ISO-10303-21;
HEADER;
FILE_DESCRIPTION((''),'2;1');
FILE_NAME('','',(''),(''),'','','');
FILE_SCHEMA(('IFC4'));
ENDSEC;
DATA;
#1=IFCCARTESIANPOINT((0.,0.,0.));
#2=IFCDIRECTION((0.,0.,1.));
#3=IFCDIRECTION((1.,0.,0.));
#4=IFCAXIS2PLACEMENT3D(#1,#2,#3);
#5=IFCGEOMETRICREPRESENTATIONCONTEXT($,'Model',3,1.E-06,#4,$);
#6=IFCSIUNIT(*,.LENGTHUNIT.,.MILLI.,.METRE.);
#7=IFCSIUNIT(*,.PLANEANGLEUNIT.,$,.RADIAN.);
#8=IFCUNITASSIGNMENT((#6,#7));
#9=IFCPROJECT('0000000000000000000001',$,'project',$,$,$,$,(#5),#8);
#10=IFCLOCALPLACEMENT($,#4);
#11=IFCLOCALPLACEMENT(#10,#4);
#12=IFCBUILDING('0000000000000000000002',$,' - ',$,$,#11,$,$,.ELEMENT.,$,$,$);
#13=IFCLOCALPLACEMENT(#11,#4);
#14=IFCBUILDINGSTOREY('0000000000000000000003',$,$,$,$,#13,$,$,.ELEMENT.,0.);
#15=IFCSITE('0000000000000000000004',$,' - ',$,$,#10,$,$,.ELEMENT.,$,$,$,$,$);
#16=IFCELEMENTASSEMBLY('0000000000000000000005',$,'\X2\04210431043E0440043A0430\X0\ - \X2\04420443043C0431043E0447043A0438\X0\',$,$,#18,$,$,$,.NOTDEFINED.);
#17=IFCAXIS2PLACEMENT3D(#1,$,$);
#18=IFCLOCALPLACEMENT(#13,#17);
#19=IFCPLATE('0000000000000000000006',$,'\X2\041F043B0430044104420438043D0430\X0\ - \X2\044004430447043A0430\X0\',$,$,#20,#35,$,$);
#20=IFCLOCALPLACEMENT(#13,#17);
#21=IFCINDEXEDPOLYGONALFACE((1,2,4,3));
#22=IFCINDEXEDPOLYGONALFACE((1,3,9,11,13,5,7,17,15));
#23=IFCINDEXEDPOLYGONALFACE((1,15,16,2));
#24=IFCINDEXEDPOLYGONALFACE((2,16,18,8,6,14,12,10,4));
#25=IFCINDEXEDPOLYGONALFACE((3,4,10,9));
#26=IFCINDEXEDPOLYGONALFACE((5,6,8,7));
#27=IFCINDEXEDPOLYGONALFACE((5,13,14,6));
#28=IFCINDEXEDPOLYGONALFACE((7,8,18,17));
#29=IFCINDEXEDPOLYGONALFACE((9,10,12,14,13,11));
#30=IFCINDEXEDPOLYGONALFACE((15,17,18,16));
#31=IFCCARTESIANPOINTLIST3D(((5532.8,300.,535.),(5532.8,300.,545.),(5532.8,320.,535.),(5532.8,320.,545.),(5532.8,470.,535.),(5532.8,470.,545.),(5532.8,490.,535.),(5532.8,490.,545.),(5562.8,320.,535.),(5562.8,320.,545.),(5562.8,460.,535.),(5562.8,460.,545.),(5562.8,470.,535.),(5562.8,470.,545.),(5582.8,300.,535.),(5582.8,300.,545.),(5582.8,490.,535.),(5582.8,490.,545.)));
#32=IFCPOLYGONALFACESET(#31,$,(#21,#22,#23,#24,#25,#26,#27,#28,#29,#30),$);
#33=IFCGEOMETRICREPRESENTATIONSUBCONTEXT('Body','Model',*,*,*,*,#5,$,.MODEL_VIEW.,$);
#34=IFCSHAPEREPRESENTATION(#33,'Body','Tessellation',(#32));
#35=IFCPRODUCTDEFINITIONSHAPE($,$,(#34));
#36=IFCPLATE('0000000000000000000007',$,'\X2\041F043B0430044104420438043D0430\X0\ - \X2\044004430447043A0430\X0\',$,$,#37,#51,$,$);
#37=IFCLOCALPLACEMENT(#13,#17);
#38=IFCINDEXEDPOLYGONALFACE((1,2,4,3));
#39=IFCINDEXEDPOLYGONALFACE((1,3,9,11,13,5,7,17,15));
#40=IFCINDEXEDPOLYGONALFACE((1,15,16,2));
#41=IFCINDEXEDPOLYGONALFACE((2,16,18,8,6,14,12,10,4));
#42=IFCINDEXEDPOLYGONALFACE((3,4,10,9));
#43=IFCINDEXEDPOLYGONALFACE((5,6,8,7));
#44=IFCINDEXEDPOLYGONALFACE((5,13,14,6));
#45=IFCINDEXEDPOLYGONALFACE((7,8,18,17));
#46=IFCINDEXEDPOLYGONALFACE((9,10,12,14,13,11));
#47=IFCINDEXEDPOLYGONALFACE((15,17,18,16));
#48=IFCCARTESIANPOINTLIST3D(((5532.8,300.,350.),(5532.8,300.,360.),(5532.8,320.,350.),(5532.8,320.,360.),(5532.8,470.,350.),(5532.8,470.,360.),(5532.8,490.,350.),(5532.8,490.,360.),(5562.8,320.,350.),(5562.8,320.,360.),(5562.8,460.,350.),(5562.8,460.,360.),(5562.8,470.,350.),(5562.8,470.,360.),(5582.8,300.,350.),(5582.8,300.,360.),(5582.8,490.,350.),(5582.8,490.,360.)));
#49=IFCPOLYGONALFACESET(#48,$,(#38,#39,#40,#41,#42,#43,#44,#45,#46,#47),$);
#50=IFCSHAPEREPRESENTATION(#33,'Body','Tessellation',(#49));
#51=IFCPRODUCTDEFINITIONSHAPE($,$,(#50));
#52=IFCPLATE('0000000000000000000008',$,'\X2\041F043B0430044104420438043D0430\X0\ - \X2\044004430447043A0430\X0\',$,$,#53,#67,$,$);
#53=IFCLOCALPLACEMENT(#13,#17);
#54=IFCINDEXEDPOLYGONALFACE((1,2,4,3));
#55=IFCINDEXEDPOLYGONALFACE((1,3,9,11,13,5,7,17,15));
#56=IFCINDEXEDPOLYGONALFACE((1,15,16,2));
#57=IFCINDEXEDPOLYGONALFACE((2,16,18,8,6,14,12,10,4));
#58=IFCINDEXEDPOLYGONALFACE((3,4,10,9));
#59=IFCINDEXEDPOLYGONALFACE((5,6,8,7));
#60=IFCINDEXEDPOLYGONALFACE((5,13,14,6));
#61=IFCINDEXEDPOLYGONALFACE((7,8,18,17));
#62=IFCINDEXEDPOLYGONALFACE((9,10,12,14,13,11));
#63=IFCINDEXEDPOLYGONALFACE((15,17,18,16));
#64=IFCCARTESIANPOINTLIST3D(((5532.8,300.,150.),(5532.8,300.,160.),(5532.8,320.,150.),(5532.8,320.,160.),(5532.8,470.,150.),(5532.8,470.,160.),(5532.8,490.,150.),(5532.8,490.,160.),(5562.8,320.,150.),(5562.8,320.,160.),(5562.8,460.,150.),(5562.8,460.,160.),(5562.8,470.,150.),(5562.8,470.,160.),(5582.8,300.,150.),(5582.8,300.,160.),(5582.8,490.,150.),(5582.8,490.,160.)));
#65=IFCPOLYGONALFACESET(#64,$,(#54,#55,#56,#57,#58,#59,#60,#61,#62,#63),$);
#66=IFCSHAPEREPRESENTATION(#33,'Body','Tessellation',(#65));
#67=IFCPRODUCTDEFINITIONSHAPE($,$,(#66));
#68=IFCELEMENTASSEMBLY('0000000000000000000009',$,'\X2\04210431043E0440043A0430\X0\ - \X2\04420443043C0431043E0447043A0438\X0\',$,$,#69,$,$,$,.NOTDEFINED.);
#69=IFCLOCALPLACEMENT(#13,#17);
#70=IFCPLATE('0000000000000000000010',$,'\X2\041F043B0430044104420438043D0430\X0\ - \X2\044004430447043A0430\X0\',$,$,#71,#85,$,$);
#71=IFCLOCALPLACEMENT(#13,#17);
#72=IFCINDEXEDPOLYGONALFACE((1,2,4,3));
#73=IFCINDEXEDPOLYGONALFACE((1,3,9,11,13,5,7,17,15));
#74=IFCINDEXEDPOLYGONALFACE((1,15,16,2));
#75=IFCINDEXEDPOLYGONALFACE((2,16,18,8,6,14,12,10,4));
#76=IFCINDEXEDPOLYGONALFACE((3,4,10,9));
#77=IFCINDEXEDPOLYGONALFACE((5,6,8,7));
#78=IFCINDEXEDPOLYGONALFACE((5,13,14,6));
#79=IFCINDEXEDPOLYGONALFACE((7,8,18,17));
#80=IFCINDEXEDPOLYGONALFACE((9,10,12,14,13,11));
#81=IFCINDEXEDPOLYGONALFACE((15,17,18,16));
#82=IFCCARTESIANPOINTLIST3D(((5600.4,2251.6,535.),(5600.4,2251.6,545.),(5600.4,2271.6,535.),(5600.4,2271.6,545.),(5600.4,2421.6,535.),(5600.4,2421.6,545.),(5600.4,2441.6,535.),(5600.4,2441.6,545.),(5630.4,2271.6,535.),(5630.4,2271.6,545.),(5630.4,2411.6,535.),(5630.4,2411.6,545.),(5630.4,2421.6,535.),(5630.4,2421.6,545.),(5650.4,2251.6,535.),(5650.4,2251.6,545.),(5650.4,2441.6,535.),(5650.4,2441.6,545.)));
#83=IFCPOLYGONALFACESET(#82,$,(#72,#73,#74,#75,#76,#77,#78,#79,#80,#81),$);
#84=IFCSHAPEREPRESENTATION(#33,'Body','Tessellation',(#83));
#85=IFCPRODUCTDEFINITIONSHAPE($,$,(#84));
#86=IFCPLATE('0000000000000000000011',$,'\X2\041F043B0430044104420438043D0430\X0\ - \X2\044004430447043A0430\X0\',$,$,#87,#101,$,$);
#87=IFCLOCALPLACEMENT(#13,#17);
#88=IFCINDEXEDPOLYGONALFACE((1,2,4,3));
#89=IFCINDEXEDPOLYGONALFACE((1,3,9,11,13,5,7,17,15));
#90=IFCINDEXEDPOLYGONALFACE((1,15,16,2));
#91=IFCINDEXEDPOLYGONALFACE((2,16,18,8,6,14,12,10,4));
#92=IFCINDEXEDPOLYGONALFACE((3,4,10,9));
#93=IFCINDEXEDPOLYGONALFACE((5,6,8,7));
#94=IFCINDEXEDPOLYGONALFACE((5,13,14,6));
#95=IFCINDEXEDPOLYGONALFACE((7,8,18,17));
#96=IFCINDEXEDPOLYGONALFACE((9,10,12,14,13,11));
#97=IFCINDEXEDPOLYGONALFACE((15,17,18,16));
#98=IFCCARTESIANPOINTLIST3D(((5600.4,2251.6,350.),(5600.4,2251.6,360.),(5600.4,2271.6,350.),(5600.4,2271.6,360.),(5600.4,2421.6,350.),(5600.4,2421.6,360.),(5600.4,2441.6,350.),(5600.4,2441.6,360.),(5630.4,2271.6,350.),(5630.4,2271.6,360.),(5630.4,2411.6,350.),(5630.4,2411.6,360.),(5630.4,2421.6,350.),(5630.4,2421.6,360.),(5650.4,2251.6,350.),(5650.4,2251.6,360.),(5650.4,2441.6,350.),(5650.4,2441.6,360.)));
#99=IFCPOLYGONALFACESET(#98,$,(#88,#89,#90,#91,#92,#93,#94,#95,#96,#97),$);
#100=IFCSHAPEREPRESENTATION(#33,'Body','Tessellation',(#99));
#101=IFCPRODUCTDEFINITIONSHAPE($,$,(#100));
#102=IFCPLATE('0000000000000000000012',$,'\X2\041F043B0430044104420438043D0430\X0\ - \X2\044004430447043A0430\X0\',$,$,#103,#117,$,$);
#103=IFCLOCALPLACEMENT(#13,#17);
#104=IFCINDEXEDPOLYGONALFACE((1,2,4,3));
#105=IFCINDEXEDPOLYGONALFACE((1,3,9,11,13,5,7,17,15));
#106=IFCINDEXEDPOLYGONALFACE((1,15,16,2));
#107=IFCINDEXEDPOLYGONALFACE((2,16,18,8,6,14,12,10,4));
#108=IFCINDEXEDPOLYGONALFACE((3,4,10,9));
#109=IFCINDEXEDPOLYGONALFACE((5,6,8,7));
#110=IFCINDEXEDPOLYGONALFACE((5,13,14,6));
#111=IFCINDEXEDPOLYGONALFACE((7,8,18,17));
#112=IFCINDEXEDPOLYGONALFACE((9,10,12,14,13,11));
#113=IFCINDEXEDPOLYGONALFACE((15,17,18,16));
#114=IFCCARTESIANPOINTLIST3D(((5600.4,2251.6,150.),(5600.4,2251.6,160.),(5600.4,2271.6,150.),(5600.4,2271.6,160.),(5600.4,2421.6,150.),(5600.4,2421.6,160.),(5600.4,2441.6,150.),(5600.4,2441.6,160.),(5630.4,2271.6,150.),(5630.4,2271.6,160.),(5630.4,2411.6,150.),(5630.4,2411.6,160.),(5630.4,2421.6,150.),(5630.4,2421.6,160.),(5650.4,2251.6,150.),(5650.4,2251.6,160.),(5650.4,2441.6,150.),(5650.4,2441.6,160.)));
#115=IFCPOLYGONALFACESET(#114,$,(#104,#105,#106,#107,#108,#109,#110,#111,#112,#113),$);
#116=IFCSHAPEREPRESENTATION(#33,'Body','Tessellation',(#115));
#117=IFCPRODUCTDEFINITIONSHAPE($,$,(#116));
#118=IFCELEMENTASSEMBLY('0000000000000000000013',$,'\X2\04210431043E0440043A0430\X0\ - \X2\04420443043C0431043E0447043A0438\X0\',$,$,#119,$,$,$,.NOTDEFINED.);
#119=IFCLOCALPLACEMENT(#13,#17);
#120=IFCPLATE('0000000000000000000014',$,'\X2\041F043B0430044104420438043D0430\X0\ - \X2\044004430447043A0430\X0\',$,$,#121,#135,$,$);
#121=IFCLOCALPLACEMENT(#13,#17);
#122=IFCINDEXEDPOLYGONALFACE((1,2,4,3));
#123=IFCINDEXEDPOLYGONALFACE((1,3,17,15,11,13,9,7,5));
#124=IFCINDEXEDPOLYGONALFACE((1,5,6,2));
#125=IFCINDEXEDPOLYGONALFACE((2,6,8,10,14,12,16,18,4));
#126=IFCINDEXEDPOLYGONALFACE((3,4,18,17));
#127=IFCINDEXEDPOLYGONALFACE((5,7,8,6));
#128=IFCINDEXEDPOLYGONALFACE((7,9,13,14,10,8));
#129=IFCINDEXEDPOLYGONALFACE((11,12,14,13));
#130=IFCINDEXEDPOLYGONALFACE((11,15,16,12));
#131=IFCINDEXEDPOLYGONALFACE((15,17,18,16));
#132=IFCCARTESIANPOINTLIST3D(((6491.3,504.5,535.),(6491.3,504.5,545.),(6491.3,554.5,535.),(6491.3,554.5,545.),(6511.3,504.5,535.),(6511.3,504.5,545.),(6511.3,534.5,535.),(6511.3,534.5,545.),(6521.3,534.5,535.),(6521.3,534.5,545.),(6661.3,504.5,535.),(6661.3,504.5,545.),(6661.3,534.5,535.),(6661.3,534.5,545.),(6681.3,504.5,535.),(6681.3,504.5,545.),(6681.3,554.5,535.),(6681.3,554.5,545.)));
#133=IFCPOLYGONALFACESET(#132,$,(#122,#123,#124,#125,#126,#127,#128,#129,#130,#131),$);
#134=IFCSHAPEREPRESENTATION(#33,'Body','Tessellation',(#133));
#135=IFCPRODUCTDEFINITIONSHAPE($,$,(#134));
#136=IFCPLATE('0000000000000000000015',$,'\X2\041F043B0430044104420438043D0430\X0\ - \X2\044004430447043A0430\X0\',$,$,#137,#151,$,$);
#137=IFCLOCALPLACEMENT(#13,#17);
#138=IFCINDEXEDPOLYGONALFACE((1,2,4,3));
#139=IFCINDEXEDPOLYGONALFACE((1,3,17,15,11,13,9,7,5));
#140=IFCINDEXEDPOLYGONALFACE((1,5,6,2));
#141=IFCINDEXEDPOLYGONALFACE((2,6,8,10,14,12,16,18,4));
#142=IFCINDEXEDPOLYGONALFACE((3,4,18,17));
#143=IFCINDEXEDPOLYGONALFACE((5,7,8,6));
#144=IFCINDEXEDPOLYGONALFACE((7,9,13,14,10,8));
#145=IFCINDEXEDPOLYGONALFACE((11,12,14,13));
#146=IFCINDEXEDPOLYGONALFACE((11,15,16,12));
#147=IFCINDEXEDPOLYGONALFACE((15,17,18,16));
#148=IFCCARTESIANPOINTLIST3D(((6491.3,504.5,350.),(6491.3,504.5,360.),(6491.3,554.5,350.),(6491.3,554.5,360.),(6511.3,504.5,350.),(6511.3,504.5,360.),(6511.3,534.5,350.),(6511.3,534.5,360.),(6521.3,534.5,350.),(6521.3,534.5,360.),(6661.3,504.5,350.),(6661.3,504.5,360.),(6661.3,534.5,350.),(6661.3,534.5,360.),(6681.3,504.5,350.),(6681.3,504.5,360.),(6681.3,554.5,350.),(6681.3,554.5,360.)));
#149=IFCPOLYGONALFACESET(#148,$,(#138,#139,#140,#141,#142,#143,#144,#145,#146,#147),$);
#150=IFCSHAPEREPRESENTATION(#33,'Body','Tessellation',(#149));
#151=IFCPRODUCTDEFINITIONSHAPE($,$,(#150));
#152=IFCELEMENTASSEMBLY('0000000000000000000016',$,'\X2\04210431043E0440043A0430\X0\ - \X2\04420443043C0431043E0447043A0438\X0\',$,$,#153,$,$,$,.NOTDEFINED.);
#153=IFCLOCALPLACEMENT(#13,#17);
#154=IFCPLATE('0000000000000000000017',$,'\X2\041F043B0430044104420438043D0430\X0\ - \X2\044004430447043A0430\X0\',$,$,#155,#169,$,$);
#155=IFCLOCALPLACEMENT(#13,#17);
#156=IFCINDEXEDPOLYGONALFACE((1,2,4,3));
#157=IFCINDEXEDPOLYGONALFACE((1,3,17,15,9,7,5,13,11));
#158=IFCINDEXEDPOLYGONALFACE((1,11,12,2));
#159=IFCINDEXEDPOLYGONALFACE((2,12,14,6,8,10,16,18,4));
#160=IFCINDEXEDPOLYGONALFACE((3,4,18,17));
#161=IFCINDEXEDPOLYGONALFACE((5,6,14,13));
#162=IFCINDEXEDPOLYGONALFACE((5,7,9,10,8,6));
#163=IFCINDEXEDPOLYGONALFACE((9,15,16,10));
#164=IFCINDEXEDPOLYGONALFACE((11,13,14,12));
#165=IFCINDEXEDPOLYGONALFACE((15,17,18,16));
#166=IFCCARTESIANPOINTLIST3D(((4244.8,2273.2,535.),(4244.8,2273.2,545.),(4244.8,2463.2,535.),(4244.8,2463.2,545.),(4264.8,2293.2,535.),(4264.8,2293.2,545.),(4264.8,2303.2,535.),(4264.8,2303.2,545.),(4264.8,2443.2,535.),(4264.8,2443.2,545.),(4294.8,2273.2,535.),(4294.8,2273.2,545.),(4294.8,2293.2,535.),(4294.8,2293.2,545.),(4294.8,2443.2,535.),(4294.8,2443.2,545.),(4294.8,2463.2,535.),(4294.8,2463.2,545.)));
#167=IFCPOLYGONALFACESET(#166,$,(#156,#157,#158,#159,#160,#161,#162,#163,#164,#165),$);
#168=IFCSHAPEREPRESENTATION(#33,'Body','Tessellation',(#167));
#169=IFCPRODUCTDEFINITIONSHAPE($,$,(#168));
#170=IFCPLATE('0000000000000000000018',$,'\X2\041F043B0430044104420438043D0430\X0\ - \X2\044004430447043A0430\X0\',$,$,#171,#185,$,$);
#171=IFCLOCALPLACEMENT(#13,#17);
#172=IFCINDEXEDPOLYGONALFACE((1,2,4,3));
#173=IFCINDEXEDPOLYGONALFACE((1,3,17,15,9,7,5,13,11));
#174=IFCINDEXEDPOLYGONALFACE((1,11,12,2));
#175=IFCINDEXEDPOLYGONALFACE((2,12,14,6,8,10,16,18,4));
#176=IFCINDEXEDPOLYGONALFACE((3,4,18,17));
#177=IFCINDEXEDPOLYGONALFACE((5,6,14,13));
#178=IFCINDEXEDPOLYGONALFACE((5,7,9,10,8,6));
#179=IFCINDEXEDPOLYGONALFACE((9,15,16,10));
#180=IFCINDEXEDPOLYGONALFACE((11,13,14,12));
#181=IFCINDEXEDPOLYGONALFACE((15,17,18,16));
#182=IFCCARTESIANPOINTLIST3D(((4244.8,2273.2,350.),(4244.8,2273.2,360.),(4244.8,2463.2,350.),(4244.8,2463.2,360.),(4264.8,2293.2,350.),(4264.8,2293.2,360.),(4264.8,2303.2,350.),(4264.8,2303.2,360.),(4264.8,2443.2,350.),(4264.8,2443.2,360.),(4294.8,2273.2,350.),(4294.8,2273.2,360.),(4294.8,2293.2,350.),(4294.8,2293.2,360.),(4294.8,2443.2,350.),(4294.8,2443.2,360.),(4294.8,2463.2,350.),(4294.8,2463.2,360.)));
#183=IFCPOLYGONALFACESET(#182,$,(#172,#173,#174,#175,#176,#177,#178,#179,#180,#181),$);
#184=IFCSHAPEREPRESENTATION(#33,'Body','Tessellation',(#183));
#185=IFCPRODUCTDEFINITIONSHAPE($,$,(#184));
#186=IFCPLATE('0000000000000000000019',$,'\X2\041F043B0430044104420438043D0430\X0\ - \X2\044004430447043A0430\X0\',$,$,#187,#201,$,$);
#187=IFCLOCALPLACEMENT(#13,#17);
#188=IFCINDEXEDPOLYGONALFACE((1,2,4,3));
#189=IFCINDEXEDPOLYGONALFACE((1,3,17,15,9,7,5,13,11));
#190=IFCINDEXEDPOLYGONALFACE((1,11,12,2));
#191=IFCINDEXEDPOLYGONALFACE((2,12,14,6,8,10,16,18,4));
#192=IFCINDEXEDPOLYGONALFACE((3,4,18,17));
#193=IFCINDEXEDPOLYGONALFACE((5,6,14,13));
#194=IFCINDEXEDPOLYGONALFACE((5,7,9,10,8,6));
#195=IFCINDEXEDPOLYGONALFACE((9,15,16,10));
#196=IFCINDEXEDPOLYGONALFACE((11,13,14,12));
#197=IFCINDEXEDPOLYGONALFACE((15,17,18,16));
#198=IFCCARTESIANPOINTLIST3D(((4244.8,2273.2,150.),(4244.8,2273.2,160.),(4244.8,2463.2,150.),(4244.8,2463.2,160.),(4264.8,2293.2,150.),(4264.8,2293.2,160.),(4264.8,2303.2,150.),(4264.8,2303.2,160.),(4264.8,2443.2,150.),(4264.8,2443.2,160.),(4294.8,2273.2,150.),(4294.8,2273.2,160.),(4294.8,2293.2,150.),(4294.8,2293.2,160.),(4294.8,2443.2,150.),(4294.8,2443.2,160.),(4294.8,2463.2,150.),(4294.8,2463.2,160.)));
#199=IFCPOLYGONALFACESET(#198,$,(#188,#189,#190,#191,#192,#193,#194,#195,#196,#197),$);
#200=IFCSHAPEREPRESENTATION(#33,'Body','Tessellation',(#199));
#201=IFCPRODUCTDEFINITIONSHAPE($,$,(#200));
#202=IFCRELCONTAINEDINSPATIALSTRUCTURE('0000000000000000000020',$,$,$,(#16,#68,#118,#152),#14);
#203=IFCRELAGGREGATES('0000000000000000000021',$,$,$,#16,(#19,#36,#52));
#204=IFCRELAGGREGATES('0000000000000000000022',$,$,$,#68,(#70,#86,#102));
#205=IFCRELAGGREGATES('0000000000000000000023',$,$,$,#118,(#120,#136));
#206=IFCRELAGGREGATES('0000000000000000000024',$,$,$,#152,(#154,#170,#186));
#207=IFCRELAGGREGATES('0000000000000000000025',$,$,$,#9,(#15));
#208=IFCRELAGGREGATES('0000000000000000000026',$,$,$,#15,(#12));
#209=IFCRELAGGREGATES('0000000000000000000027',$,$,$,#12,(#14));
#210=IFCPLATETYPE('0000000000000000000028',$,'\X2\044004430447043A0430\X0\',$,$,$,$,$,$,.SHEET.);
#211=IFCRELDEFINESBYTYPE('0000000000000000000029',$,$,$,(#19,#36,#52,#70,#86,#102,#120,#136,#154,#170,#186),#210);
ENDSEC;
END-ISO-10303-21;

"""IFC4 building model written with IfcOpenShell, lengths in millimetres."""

from ifc_helpers import new_model, si_unit, frame, origin_with_axes, place, context, subcontext, project, spatial, line, indexed_curve, outline, extrude, source, transform, mapped, type_object, element, aggregate, save


model = new_model("IFC4")

# Units and contexts
model_context = context("Model", 3, precision=1e-06, world=origin_with_axes())
body_context = subcontext(model_context, "Body", "Model", "MODEL_VIEW")
ifc_project = project(units=[si_unit("LENGTHUNIT", "METRE", prefix="MILLI"), si_unit("PLANEANGLEUNIT", "RADIAN")], contexts=[model_context])

# Site, building, storey
site_placement = place(None, origin_with_axes())
site = spatial("IfcSite", under=ifc_project, at=site_placement, Name=" - ", CompositionType="ELEMENT")
building_placement = place(site_placement, origin_with_axes())
building = spatial("IfcBuilding", under=site, at=building_placement, Name=" - ", CompositionType="ELEMENT")
storey_placement = place(building_placement, origin_with_axes())
storey = spatial("IfcBuildingStorey", under=building, at=storey_placement, CompositionType="ELEMENT", Elevation=0.0)

# Shared definitions
plate_type = type_object("IfcPlateType", Name="ручка", PredefinedType="SHEET")
shared_shape_1 = source(origin_with_axes(), body_context, "Body", "SweptSolid", [
    extrude(outline(indexed_curve([(-95.0, -25.0), (-75.0, -25.0), (-75.0, 5.0), (-65.0, 5.0), (75.0, 5.0), (75.0, -25.0), (95.0, -25.0), (95.0, 25.0), (-95.0, 25.0)], segments=[line(1, 2), line(2, 3), line(3, 4), line(4, 5), line(5, 6), line(6, 7), line(7, 8), line(8, 9), line(9, 1)])), origin_with_axes(), (0.0, 0.0, 1.0), 10.0),
])

# Element assemblies, plates
assembly_1_placement = place(storey_placement, frame((5532.8, 195.0, 0.0), z_axis=(0.0, 0.0, 1.0), x_axis=(0.0, 1.0, 0.0)))
assembly_1 = element("IfcElementAssembly", 1, at=assembly_1_placement, inside=storey, Name="Сборка - тумбочки", PredefinedType="NOTDEFINED")
plate_1_placement = place(assembly_1_placement, frame((200.0, -25.0, 535.0), z_axis=(0.0, 0.0, 1.0), x_axis=(-1.0, 0.0, 0.0)))
plate_1 = element("IfcPlate", 2, at=plate_1_placement, type_object=plate_type, Name="Пластина - ручка", context=body_context, shape_type="MappedRepresentation", body=[
    mapped(shared_shape_1, transform((0.0, 0.0, 0.0), x_axis=(1.0, 0.0, 0.0), y_axis=(0.0, 1.0, 0.0), z_axis=(0.0, 0.0, 1.0), scale=1.0)),
])
plate_2_placement = place(assembly_1_placement, frame((200.0, -25.0, 350.0), z_axis=(0.0, 0.0, 1.0), x_axis=(-1.0, 0.0, 0.0)))
plate_2 = element("IfcPlate", 3, at=plate_2_placement, type_object=plate_type, Name="Пластина - ручка", context=body_context, shape_type="MappedRepresentation", body=[
    mapped(shared_shape_1, transform((0.0, 0.0, 0.0), x_axis=(1.0, 0.0, 0.0), y_axis=(0.0, 1.0, 0.0), z_axis=(0.0, 0.0, 1.0), scale=1.0)),
])
plate_3_placement = place(assembly_1_placement, frame((200.0, -25.0, 150.0), z_axis=(0.0, 0.0, 1.0), x_axis=(-1.0, 0.0, 0.0)))
plate_3 = element("IfcPlate", 4, at=plate_3_placement, type_object=plate_type, Name="Пластина - ручка", context=body_context, shape_type="MappedRepresentation", body=[
    mapped(shared_shape_1, transform((0.0, 0.0, 0.0), x_axis=(1.0, 0.0, 0.0), y_axis=(0.0, 1.0, 0.0), z_axis=(0.0, 0.0, 1.0), scale=1.0)),
])
aggregate(assembly_1, [plate_1, plate_2, plate_3])
assembly_2_placement = place(storey_placement, frame((5600.4, 2146.6, 0.0), z_axis=(0.0, 0.0, 1.0), x_axis=(0.0, 1.0, 0.0)))
assembly_2 = element("IfcElementAssembly", 5, at=assembly_2_placement, inside=storey, Name="Сборка - тумбочки", PredefinedType="NOTDEFINED")
plate_4_placement = place(assembly_2_placement, frame((200.0, -25.0, 535.0), z_axis=(0.0, 0.0, 1.0), x_axis=(-1.0, 0.0, 0.0)))
plate_4 = element("IfcPlate", 6, at=plate_4_placement, type_object=plate_type, Name="Пластина - ручка", context=body_context, shape_type="MappedRepresentation", body=[
    mapped(shared_shape_1, transform((0.0, 0.0, 0.0), x_axis=(1.0, 0.0, 0.0), y_axis=(0.0, 1.0, 0.0), z_axis=(0.0, 0.0, 1.0), scale=1.0)),
])
plate_5_placement = place(assembly_2_placement, frame((200.0, -25.0, 350.0), z_axis=(0.0, 0.0, 1.0), x_axis=(-1.0, 0.0, 0.0)))
plate_5 = element("IfcPlate", 7, at=plate_5_placement, type_object=plate_type, Name="Пластина - ручка", context=body_context, shape_type="MappedRepresentation", body=[
    mapped(shared_shape_1, transform((0.0, 0.0, 0.0), x_axis=(1.0, 0.0, 0.0), y_axis=(0.0, 1.0, 0.0), z_axis=(0.0, 0.0, 1.0), scale=1.0)),
])
plate_6_placement = place(assembly_2_placement, frame((200.0, -25.0, 150.0), z_axis=(0.0, 0.0, 1.0), x_axis=(-1.0, 0.0, 0.0)))
plate_6 = element("IfcPlate", 8, at=plate_6_placement, type_object=plate_type, Name="Пластина - ручка", context=body_context, shape_type="MappedRepresentation", body=[
    mapped(shared_shape_1, transform((0.0, 0.0, 0.0), x_axis=(1.0, 0.0, 0.0), y_axis=(0.0, 1.0, 0.0), z_axis=(0.0, 0.0, 1.0), scale=1.0)),
])
aggregate(assembly_2, [plate_4, plate_5, plate_6])
assembly_3_placement = place(storey_placement, frame((6786.3, 504.5, 0.0), z_axis=(0.0, 0.0, 1.0), x_axis=(-1.0, 0.0, 0.0)))
assembly_3 = element("IfcElementAssembly", 9, at=assembly_3_placement, inside=storey, Name="Сборка - тумбочки", PredefinedType="NOTDEFINED")
plate_7_placement = place(assembly_3_placement, frame((200.0, -25.0, 535.0), z_axis=(0.0, 0.0, 1.0), x_axis=(-1.0, 0.0, 0.0)))
plate_7 = element("IfcPlate", 10, at=plate_7_placement, type_object=plate_type, Name="Пластина - ручка", context=body_context, shape_type="MappedRepresentation", body=[
    mapped(shared_shape_1, transform((0.0, 0.0, 0.0), x_axis=(1.0, 0.0, 0.0), y_axis=(0.0, 1.0, 0.0), z_axis=(0.0, 0.0, 1.0), scale=1.0)),
])
plate_8_placement = place(assembly_3_placement, frame((200.0, -25.0, 350.0), z_axis=(0.0, 0.0, 1.0), x_axis=(-1.0, 0.0, 0.0)))
plate_8 = element("IfcPlate", 11, at=plate_8_placement, type_object=plate_type, Name="Пластина - ручка", context=body_context, shape_type="MappedRepresentation", body=[
    mapped(shared_shape_1, transform((0.0, 0.0, 0.0), x_axis=(1.0, 0.0, 0.0), y_axis=(0.0, 1.0, 0.0), z_axis=(0.0, 0.0, 1.0), scale=1.0)),
])
aggregate(assembly_3, [plate_7, plate_8])
assembly_4_placement = place(storey_placement, frame((4294.8, 2568.2, 0.0), z_axis=(0.0, 0.0, 1.0), x_axis=(0.0, -1.0, 0.0)))
assembly_4 = element("IfcElementAssembly", 12, at=assembly_4_placement, inside=storey, Name="Сборка - тумбочки", PredefinedType="NOTDEFINED")
plate_9_placement = place(assembly_4_placement, frame((200.0, -25.0, 535.0), z_axis=(0.0, 0.0, 1.0), x_axis=(-1.0, 0.0, 0.0)))
plate_9 = element("IfcPlate", 13, at=plate_9_placement, type_object=plate_type, Name="Пластина - ручка", context=body_context, shape_type="MappedRepresentation", body=[
    mapped(shared_shape_1, transform((0.0, 0.0, 0.0), x_axis=(1.0, 0.0, 0.0), y_axis=(0.0, 1.0, 0.0), z_axis=(0.0, 0.0, 1.0), scale=1.0)),
])
plate_10_placement = place(assembly_4_placement, frame((200.0, -25.0, 350.0), z_axis=(0.0, 0.0, 1.0), x_axis=(-1.0, 0.0, 0.0)))
plate_10 = element("IfcPlate", 14, at=plate_10_placement, type_object=plate_type, Name="Пластина - ручка", context=body_context, shape_type="MappedRepresentation", body=[
    mapped(shared_shape_1, transform((0.0, 0.0, 0.0), x_axis=(1.0, 0.0, 0.0), y_axis=(0.0, 1.0, 0.0), z_axis=(0.0, 0.0, 1.0), scale=1.0)),
])
plate_11_placement = place(assembly_4_placement, frame((200.0, -25.0, 150.0), z_axis=(0.0, 0.0, 1.0), x_axis=(-1.0, 0.0, 0.0)))
plate_11 = element("IfcPlate", 15, at=plate_11_placement, type_object=plate_type, Name="Пластина - ручка", context=body_context, shape_type="MappedRepresentation", body=[
    mapped(shared_shape_1, transform((0.0, 0.0, 0.0), x_axis=(1.0, 0.0, 0.0), y_axis=(0.0, 1.0, 0.0), z_axis=(0.0, 0.0, 1.0), scale=1.0)),
])
aggregate(assembly_4, [plate_9, plate_10, plate_11])

save(model, "model.ifc")
